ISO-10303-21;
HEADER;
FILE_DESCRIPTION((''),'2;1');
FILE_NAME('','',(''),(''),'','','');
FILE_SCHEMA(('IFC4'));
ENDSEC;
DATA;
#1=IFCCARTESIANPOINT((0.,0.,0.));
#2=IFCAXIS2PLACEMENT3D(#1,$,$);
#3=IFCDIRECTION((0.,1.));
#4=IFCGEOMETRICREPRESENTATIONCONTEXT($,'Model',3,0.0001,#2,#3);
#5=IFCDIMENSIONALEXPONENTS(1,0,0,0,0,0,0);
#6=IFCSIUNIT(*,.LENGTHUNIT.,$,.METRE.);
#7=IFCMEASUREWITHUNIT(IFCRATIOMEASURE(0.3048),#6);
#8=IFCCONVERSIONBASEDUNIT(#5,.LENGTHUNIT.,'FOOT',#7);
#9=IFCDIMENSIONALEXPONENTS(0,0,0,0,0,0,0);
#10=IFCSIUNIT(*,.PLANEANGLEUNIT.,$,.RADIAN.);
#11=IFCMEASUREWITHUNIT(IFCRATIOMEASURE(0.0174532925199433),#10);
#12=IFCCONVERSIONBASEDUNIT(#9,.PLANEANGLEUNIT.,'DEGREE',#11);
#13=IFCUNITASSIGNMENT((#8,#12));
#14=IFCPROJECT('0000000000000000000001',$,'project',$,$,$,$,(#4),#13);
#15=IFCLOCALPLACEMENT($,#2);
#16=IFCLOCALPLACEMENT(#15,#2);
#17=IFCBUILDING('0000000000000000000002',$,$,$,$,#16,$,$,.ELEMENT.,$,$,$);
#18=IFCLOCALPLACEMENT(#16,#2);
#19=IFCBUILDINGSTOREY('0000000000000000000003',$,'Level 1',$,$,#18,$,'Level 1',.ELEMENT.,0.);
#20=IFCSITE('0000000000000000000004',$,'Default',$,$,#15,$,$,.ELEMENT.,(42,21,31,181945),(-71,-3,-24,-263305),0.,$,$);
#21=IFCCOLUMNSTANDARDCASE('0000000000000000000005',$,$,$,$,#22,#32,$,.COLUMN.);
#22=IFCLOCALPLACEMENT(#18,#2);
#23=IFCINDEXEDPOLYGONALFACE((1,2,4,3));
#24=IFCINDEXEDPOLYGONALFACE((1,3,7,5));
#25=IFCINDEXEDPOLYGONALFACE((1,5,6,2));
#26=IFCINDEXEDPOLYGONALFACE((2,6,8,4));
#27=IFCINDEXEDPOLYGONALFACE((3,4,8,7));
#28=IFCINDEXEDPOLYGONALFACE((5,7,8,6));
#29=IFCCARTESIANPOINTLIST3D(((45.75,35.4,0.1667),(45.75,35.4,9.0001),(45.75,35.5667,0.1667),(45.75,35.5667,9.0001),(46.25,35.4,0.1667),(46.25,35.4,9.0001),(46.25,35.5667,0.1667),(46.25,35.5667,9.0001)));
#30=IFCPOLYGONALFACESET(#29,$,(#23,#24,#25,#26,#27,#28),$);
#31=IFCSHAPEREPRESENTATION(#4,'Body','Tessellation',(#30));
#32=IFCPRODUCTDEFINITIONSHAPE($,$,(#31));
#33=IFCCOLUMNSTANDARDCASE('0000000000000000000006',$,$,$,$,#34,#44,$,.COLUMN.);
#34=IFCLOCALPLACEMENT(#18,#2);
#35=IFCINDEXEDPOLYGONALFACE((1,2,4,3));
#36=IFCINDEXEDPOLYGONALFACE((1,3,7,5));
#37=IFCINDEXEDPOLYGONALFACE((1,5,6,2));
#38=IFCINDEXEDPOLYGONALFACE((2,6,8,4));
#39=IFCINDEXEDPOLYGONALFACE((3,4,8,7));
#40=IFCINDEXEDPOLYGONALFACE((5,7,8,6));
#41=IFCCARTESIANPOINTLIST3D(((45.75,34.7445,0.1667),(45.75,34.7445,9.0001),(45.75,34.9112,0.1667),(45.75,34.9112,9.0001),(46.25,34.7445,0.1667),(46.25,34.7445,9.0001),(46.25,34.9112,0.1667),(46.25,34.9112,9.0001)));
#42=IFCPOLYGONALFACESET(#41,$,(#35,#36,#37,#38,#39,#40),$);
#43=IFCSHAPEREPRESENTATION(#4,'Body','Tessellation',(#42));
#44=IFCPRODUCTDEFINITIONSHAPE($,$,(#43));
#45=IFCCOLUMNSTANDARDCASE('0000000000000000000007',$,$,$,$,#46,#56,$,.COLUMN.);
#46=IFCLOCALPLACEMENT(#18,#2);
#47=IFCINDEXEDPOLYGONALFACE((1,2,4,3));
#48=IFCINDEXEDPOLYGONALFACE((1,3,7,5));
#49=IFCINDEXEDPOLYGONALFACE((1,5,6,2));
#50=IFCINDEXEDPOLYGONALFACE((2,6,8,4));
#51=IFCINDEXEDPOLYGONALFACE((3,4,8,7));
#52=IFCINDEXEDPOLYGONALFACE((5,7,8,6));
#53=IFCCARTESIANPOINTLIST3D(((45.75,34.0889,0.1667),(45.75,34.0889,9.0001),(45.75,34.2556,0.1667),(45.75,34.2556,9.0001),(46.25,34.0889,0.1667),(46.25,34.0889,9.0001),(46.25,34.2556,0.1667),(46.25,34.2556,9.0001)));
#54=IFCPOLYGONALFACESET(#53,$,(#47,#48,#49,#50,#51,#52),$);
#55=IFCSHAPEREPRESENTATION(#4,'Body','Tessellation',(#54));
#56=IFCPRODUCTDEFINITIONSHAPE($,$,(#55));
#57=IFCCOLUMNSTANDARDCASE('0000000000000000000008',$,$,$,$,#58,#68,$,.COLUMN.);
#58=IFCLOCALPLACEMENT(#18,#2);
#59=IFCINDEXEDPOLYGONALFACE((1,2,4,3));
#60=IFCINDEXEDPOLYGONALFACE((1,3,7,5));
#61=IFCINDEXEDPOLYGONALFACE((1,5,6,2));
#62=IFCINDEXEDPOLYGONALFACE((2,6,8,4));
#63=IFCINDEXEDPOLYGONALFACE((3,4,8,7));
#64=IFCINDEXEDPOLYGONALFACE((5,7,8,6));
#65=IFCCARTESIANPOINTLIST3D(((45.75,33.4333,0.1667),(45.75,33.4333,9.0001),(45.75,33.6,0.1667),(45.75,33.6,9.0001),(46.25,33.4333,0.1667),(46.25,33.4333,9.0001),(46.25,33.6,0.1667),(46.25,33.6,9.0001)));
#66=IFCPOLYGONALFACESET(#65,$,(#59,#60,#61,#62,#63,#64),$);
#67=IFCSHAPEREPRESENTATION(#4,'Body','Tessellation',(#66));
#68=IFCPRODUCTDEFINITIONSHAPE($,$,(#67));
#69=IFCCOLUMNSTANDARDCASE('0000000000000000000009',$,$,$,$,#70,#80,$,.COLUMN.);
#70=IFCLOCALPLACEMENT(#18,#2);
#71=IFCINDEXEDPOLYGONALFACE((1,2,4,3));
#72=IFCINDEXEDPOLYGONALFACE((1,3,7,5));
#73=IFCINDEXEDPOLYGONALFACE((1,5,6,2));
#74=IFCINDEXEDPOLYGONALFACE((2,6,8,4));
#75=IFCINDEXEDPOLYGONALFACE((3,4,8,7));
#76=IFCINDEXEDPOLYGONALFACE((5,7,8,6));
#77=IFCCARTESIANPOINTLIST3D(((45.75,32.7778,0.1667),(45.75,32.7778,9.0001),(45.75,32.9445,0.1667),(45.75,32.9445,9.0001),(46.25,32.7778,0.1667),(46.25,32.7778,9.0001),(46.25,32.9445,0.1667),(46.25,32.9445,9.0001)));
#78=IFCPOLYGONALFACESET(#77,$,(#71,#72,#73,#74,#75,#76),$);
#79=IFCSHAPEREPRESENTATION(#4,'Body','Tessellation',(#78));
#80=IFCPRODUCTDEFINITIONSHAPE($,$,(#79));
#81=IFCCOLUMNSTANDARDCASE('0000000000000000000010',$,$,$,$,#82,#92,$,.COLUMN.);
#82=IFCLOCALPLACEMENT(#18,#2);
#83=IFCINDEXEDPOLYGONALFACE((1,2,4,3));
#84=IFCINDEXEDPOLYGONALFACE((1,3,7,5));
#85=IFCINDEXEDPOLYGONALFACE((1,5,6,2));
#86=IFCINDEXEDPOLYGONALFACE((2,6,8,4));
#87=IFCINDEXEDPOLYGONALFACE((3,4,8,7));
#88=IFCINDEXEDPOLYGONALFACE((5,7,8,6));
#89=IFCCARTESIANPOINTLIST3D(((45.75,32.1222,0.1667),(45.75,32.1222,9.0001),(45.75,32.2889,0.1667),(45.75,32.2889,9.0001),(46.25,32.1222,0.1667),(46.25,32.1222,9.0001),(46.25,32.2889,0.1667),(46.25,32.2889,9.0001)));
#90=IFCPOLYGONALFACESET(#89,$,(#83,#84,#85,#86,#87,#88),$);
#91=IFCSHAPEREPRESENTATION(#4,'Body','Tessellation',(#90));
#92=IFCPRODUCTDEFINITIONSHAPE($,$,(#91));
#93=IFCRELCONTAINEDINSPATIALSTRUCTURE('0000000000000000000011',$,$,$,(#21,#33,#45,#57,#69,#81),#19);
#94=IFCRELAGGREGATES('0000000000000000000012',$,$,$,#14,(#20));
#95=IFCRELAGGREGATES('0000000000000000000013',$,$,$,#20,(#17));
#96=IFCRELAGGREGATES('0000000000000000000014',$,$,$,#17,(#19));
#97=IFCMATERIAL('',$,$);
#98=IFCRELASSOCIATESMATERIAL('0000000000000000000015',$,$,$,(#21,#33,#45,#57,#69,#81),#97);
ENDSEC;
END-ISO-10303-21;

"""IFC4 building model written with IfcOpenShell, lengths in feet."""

from ifc_helpers import new_model, entity, si_unit, converted_unit, direction, frame, origin, place, context, project, spatial, rectangle, extrude, material, element, save


model = new_model("IFC4")

# Units and contexts
model_context = context("Model", 3, precision=0.0001, world=origin(), true_north=direction((0.0, 1.0)))
ifc_project = project(units=[converted_unit("LENGTHUNIT", "FOOT", entity("IfcRatioMeasure", 0.3048), si_unit("LENGTHUNIT", "METRE"), dimensions=[1, 0, 0, 0, 0, 0, 0]), converted_unit("PLANEANGLEUNIT", "DEGREE", entity("IfcRatioMeasure", 0.0174532925199433), si_unit("PLANEANGLEUNIT", "RADIAN"), dimensions=[0, 0, 0, 0, 0, 0, 0])], contexts=[model_context])

# Site, building, storey
site_placement = place(None, origin())
site = spatial("IfcSite", under=ifc_project, at=site_placement, Name="Default", CompositionType="ELEMENT", RefLatitude=(42, 21, 31, 181945), RefLongitude=(-71, -3, -24, -263305), RefElevation=0.0)
building_placement = place(site_placement, origin())
building = spatial("IfcBuilding", under=site, at=building_placement, CompositionType="ELEMENT")
storey_placement = place(building_placement, origin())
storey = spatial("IfcBuildingStorey", under=building, at=storey_placement, Name="Level 1", LongName="Level 1", CompositionType="ELEMENT", Elevation=0.0)

# Columns
ifc_material_1 = material(Name="")
placement_1 = place(storey_placement, frame((46.0, 46.25, 0.0), z_axis=(0.0, 0.0, 1.0), x_axis=(0.0, -1.0, 0.0)))
for number, where, z_axis, x_axis in (
    (1, (10.7667, 0.0, 0.1667), (0.0, 0.0, 1.0), (1.0, 0.0, 0.0)),
    (2, (11.4222, 0.0, 0.1667), (0.0, 0.0, 1.0), (1.0, 0.0, 0.0)),
    (3, (12.0778, 0.0, 0.1667), (0.0, 0.0, 1.0), (1.0, 0.0, 0.0)),
    (4, (12.7334, 0.0, 0.1667), (0.0, 0.0, 1.0), (1.0, 0.0, 0.0)),
    (5, (13.3889, 0.0, 0.1667), (0.0, 0.0, 1.0), (1.0, 0.0, 0.0)),
    (6, (14.0445, 0.0, 0.1667), (0.0, 0.0, 1.0), (1.0, 0.0, 0.0)),
):
    element("IfcColumnStandardCase", number, at=place(placement_1, frame(where, z_axis=z_axis, x_axis=x_axis)), inside=storey, material=ifc_material_1, PredefinedType="COLUMN", context=model_context, shape_type="SweptSolid", body=[
        extrude(rectangle(XDim=0.1667, YDim=0.5), origin(), (0.0, 0.0, 1.0), 8.8334),
    ])

save(model, "model.ifc")
